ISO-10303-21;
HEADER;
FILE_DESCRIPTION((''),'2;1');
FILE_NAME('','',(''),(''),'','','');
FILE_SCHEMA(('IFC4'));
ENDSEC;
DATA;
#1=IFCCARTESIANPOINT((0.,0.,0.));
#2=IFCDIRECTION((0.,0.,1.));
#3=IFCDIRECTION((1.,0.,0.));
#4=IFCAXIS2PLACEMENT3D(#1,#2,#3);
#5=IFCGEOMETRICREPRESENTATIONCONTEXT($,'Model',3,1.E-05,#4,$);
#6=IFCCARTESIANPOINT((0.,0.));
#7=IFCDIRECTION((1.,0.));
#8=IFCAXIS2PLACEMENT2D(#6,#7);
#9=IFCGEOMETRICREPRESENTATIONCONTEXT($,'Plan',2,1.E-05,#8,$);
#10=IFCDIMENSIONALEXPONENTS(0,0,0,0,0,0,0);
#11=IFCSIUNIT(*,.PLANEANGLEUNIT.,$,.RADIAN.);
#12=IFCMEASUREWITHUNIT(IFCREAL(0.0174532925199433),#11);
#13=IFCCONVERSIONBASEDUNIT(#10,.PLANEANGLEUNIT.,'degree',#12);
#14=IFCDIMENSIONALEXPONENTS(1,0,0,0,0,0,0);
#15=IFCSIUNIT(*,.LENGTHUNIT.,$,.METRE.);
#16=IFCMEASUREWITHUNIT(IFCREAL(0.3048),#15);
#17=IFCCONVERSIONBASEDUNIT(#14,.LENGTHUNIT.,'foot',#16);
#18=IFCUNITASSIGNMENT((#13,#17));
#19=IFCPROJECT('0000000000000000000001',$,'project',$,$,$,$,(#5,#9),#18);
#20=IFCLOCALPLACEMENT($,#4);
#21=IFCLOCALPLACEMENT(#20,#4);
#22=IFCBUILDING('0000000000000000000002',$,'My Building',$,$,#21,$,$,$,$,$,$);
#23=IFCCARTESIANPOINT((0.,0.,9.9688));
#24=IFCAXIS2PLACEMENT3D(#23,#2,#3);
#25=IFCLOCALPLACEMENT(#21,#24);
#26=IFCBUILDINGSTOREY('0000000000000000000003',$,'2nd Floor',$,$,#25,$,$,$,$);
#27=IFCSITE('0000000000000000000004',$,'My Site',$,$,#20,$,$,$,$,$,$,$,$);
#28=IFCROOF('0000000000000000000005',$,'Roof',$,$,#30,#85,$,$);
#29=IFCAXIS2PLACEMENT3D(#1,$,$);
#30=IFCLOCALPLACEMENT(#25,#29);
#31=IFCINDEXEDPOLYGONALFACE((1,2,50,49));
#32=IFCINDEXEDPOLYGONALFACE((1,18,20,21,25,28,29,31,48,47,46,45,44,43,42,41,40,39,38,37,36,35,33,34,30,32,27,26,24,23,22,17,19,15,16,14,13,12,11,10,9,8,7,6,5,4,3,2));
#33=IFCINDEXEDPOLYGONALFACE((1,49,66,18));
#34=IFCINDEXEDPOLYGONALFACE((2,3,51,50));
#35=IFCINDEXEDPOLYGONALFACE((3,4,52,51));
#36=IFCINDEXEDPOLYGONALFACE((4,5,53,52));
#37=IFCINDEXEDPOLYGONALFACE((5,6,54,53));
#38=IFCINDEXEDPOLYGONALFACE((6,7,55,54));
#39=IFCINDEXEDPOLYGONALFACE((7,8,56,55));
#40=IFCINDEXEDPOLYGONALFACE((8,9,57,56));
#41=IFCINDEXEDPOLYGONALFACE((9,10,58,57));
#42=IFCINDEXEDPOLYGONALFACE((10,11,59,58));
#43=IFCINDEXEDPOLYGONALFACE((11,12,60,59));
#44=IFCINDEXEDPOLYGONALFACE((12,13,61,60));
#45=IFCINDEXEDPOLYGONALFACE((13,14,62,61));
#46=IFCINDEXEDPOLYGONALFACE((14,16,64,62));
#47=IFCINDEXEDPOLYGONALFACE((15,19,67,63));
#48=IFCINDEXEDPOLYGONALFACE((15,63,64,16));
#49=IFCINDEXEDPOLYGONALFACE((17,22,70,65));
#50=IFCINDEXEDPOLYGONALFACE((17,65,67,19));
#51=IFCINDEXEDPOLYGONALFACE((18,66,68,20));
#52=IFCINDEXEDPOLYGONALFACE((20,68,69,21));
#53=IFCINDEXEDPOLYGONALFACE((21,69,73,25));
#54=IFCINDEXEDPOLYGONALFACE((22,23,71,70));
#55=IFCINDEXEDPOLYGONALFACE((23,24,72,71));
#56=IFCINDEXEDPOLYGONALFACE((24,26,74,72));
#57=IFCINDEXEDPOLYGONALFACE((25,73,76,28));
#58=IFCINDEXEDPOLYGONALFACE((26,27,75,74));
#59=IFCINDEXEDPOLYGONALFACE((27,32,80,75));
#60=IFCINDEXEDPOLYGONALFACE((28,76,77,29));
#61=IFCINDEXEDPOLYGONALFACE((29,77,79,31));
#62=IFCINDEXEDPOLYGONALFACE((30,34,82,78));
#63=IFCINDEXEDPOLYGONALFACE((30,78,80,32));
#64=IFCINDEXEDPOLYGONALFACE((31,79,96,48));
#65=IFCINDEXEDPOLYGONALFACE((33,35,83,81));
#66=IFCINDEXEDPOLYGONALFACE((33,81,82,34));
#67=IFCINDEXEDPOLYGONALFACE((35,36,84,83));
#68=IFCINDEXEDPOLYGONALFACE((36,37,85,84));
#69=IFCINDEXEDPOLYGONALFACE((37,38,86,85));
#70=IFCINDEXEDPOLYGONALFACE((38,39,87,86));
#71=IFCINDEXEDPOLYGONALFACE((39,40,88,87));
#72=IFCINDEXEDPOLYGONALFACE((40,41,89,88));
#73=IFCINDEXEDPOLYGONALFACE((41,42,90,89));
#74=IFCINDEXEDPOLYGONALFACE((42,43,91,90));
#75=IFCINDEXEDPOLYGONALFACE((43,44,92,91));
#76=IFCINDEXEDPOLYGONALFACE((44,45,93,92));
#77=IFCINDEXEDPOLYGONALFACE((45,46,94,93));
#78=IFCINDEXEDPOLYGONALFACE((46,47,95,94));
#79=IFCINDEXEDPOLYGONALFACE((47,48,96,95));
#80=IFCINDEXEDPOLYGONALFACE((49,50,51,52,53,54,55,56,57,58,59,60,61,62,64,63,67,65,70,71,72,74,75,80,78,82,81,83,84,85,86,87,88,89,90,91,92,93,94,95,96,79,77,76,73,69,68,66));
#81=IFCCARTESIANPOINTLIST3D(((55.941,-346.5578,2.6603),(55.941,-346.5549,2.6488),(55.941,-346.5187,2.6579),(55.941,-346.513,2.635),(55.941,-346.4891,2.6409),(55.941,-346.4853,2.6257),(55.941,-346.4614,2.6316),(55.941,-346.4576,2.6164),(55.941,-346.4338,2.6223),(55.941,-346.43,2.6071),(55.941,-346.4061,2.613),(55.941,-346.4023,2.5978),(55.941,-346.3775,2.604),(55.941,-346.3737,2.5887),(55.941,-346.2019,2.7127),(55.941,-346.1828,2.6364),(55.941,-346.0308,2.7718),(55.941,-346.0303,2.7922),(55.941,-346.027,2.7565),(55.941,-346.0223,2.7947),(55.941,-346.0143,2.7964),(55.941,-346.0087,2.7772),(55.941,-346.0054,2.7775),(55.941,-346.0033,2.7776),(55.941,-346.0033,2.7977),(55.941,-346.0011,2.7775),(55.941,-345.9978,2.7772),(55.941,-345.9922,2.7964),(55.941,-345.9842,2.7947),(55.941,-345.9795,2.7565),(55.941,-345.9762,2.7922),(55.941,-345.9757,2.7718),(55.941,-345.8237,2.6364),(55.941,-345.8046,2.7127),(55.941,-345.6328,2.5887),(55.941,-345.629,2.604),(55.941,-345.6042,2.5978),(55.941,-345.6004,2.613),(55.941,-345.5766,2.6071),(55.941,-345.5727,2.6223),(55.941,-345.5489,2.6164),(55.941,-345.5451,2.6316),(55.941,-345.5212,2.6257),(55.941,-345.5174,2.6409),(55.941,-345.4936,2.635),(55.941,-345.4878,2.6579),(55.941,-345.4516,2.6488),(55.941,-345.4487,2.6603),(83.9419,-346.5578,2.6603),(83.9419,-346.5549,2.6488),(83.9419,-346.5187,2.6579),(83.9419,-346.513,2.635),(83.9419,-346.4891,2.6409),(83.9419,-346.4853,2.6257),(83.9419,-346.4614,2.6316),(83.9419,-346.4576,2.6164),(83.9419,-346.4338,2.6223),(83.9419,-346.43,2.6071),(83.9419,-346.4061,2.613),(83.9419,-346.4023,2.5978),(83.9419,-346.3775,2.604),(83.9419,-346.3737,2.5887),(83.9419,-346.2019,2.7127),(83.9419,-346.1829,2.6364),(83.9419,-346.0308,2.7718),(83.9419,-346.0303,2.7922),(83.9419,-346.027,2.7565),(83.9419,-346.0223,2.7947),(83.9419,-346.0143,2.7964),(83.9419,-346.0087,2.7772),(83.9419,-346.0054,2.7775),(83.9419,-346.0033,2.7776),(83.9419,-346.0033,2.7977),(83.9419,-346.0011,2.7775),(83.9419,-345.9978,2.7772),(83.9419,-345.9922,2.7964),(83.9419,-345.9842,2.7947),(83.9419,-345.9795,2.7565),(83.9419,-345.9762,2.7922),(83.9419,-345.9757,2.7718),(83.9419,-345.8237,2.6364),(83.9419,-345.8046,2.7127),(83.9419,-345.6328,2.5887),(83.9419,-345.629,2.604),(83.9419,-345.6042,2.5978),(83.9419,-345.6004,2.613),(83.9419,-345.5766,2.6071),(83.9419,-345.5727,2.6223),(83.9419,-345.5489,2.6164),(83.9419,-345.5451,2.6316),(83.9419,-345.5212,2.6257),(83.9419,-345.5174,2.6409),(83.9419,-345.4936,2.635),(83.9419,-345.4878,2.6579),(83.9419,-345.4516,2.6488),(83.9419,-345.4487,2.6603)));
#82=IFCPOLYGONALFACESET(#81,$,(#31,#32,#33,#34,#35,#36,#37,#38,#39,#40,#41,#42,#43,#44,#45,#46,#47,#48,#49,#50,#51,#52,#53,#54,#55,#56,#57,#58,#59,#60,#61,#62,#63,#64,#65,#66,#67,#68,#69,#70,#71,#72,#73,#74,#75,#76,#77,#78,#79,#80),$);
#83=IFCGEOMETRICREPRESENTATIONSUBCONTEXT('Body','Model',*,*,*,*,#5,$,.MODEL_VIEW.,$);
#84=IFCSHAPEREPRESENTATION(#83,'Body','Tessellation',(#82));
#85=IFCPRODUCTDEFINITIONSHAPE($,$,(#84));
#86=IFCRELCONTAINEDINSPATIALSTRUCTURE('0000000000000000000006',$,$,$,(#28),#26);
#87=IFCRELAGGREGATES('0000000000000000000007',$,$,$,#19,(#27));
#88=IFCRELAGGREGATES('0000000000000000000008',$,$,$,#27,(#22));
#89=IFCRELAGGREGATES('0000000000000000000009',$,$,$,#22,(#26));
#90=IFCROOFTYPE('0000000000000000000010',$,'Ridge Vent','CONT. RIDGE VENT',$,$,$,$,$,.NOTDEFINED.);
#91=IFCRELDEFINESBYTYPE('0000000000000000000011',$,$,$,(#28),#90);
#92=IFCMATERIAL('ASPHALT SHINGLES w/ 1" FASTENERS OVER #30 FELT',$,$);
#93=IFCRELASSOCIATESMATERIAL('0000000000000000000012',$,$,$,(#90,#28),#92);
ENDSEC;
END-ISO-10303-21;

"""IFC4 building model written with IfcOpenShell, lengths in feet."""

from ifc_helpers import new_model, entity, si_unit, converted_unit, frame, origin_with_axes, origin_2d_with_axis, place, context, subcontext, project, spatial, indexed_curve, outline, extrude, material, material_profile, profile_set, profile_usage, type_object, element, save


model = new_model("IFC4")

# Units and contexts
model_context = context("Model", 3, precision=1e-05, world=origin_with_axes())
plan_context = context("Plan", 2, precision=1e-05, world=origin_2d_with_axis())
body_context = subcontext(model_context, "Body", "Model", "MODEL_VIEW")
ifc_project = project(units=[converted_unit("PLANEANGLEUNIT", "degree", entity("IfcReal", 0.0174532925199433), si_unit("PLANEANGLEUNIT", "RADIAN"), dimensions=[0, 0, 0, 0, 0, 0, 0]), converted_unit("LENGTHUNIT", "foot", entity("IfcReal", 0.3048), si_unit("LENGTHUNIT", "METRE"), dimensions=[1, 0, 0, 0, 0, 0, 0])], contexts=[model_context, plan_context])

# Site, building, storey
site_placement = place(None, origin_with_axes())
site = spatial("IfcSite", under=ifc_project, at=site_placement, Name="My Site")
building_placement = place(site_placement, origin_with_axes())
building = spatial("IfcBuilding", under=site, at=building_placement, Name="My Building")
storey_placement = place(building_placement, frame((0.0, 0.0, 9.9688), z_axis=(0.0, 0.0, 1.0), x_axis=(1.0, 0.0, 0.0)))
storey = spatial("IfcBuildingStorey", under=building, at=storey_placement, Name="2nd Floor")

# Roof
ifc_material_1 = material(Name="ASPHALT SHINGLES w/ 1\" FASTENERS OVER #30 FELT")
ifc_material_profile_1 = material_profile(ifc_material_1, outline(indexed_curve([(-0.0055, -0.0205), (-0.0022, -0.0202), (0.0, -0.0201), (0.0022, -0.0202), (0.0055, -0.0205), (0.0275, -0.0259), (0.0237, -0.0412), (0.1987, -0.085), (0.1796, -0.1613), (0.3704, -0.209), (0.3742, -0.1937), (0.399, -0.1999), (0.4028, -0.1847), (0.4267, -0.1906), (0.4305, -0.1754), (0.4544, -0.1813), (0.4582, -0.1661), (0.482, -0.172), (0.4859, -0.1568), (0.5097, -0.1627), (0.5154, -0.1398), (0.5517, -0.1489), (0.5545, -0.1374), (0.027, -0.0055), (0.0191, -0.003), (0.011, -0.0013), (0.0, 0.0), (-0.011, -0.0013), (-0.019, -0.003), (-0.027, -0.0055), (-0.5545, -0.1374), (-0.5517, -0.1489), (-0.5154, -0.1398), (-0.5097, -0.1627), (-0.4859, -0.1568), (-0.482, -0.172), (-0.4582, -0.1661), (-0.4544, -0.1813), (-0.4305, -0.1754), (-0.4267, -0.1906), (-0.4028, -0.1847), (-0.399, -0.1999), (-0.3742, -0.1937), (-0.3704, -0.209), (-0.1796, -0.1613), (-0.1987, -0.085), (-0.0237, -0.0412), (-0.0275, -0.0259), (-0.0055, -0.0205)])))
ifc_profile_set_1 = profile_set([ifc_material_profile_1])
ifc_profile_usage_1 = profile_usage(ifc_profile_set_1, cardinal=5)
roof_type = type_object("IfcRoofType", Name="Ridge Vent", Description="CONT. RIDGE VENT", PredefinedType="NOTDEFINED", material=ifc_profile_set_1)
roof_placement = place(storey_placement, frame((83.9419, -346.0033, 2.7977), z_axis=(-1.0, 0.0, 0.0), x_axis=(0.0, -1.0, 0.0)))
element("IfcRoof", 1, at=roof_placement, inside=storey, type_object=roof_type, material=ifc_profile_usage_1, Name="Roof", context=body_context, shape_type="SweptSolid", body=[
    extrude(outline(indexed_curve([(-0.0055, -0.0205), (-0.0022, -0.0202), (0.0, -0.0201), (0.0022, -0.0202), (0.0055, -0.0205), (0.0275, -0.0259), (0.0237, -0.0412), (0.1987, -0.085), (0.1796, -0.1613), (0.3704, -0.209), (0.3742, -0.1937), (0.399, -0.1999), (0.4028, -0.1847), (0.4267, -0.1906), (0.4305, -0.1754), (0.4544, -0.1813), (0.4582, -0.1661), (0.482, -0.172), (0.4859, -0.1568), (0.5097, -0.1627), (0.5154, -0.1398), (0.5517, -0.1489), (0.5545, -0.1374), (0.027, -0.0055), (0.0191, -0.003), (0.011, -0.0013), (0.0, 0.0), (-0.011, -0.0013), (-0.019, -0.003), (-0.027, -0.0055), (-0.5545, -0.1374), (-0.5517, -0.1489), (-0.5154, -0.1398), (-0.5097, -0.1627), (-0.4859, -0.1568), (-0.482, -0.172), (-0.4582, -0.1661), (-0.4544, -0.1813), (-0.4305, -0.1754), (-0.4267, -0.1906), (-0.4028, -0.1847), (-0.399, -0.1999), (-0.3742, -0.1937), (-0.3704, -0.209), (-0.1796, -0.1613), (-0.1987, -0.085), (-0.0237, -0.0412), (-0.0275, -0.0259), (-0.0055, -0.0205)])), origin_with_axes(), (0.0, 0.0, 1.0), 28.0009),
])

save(model, "model.ifc")
